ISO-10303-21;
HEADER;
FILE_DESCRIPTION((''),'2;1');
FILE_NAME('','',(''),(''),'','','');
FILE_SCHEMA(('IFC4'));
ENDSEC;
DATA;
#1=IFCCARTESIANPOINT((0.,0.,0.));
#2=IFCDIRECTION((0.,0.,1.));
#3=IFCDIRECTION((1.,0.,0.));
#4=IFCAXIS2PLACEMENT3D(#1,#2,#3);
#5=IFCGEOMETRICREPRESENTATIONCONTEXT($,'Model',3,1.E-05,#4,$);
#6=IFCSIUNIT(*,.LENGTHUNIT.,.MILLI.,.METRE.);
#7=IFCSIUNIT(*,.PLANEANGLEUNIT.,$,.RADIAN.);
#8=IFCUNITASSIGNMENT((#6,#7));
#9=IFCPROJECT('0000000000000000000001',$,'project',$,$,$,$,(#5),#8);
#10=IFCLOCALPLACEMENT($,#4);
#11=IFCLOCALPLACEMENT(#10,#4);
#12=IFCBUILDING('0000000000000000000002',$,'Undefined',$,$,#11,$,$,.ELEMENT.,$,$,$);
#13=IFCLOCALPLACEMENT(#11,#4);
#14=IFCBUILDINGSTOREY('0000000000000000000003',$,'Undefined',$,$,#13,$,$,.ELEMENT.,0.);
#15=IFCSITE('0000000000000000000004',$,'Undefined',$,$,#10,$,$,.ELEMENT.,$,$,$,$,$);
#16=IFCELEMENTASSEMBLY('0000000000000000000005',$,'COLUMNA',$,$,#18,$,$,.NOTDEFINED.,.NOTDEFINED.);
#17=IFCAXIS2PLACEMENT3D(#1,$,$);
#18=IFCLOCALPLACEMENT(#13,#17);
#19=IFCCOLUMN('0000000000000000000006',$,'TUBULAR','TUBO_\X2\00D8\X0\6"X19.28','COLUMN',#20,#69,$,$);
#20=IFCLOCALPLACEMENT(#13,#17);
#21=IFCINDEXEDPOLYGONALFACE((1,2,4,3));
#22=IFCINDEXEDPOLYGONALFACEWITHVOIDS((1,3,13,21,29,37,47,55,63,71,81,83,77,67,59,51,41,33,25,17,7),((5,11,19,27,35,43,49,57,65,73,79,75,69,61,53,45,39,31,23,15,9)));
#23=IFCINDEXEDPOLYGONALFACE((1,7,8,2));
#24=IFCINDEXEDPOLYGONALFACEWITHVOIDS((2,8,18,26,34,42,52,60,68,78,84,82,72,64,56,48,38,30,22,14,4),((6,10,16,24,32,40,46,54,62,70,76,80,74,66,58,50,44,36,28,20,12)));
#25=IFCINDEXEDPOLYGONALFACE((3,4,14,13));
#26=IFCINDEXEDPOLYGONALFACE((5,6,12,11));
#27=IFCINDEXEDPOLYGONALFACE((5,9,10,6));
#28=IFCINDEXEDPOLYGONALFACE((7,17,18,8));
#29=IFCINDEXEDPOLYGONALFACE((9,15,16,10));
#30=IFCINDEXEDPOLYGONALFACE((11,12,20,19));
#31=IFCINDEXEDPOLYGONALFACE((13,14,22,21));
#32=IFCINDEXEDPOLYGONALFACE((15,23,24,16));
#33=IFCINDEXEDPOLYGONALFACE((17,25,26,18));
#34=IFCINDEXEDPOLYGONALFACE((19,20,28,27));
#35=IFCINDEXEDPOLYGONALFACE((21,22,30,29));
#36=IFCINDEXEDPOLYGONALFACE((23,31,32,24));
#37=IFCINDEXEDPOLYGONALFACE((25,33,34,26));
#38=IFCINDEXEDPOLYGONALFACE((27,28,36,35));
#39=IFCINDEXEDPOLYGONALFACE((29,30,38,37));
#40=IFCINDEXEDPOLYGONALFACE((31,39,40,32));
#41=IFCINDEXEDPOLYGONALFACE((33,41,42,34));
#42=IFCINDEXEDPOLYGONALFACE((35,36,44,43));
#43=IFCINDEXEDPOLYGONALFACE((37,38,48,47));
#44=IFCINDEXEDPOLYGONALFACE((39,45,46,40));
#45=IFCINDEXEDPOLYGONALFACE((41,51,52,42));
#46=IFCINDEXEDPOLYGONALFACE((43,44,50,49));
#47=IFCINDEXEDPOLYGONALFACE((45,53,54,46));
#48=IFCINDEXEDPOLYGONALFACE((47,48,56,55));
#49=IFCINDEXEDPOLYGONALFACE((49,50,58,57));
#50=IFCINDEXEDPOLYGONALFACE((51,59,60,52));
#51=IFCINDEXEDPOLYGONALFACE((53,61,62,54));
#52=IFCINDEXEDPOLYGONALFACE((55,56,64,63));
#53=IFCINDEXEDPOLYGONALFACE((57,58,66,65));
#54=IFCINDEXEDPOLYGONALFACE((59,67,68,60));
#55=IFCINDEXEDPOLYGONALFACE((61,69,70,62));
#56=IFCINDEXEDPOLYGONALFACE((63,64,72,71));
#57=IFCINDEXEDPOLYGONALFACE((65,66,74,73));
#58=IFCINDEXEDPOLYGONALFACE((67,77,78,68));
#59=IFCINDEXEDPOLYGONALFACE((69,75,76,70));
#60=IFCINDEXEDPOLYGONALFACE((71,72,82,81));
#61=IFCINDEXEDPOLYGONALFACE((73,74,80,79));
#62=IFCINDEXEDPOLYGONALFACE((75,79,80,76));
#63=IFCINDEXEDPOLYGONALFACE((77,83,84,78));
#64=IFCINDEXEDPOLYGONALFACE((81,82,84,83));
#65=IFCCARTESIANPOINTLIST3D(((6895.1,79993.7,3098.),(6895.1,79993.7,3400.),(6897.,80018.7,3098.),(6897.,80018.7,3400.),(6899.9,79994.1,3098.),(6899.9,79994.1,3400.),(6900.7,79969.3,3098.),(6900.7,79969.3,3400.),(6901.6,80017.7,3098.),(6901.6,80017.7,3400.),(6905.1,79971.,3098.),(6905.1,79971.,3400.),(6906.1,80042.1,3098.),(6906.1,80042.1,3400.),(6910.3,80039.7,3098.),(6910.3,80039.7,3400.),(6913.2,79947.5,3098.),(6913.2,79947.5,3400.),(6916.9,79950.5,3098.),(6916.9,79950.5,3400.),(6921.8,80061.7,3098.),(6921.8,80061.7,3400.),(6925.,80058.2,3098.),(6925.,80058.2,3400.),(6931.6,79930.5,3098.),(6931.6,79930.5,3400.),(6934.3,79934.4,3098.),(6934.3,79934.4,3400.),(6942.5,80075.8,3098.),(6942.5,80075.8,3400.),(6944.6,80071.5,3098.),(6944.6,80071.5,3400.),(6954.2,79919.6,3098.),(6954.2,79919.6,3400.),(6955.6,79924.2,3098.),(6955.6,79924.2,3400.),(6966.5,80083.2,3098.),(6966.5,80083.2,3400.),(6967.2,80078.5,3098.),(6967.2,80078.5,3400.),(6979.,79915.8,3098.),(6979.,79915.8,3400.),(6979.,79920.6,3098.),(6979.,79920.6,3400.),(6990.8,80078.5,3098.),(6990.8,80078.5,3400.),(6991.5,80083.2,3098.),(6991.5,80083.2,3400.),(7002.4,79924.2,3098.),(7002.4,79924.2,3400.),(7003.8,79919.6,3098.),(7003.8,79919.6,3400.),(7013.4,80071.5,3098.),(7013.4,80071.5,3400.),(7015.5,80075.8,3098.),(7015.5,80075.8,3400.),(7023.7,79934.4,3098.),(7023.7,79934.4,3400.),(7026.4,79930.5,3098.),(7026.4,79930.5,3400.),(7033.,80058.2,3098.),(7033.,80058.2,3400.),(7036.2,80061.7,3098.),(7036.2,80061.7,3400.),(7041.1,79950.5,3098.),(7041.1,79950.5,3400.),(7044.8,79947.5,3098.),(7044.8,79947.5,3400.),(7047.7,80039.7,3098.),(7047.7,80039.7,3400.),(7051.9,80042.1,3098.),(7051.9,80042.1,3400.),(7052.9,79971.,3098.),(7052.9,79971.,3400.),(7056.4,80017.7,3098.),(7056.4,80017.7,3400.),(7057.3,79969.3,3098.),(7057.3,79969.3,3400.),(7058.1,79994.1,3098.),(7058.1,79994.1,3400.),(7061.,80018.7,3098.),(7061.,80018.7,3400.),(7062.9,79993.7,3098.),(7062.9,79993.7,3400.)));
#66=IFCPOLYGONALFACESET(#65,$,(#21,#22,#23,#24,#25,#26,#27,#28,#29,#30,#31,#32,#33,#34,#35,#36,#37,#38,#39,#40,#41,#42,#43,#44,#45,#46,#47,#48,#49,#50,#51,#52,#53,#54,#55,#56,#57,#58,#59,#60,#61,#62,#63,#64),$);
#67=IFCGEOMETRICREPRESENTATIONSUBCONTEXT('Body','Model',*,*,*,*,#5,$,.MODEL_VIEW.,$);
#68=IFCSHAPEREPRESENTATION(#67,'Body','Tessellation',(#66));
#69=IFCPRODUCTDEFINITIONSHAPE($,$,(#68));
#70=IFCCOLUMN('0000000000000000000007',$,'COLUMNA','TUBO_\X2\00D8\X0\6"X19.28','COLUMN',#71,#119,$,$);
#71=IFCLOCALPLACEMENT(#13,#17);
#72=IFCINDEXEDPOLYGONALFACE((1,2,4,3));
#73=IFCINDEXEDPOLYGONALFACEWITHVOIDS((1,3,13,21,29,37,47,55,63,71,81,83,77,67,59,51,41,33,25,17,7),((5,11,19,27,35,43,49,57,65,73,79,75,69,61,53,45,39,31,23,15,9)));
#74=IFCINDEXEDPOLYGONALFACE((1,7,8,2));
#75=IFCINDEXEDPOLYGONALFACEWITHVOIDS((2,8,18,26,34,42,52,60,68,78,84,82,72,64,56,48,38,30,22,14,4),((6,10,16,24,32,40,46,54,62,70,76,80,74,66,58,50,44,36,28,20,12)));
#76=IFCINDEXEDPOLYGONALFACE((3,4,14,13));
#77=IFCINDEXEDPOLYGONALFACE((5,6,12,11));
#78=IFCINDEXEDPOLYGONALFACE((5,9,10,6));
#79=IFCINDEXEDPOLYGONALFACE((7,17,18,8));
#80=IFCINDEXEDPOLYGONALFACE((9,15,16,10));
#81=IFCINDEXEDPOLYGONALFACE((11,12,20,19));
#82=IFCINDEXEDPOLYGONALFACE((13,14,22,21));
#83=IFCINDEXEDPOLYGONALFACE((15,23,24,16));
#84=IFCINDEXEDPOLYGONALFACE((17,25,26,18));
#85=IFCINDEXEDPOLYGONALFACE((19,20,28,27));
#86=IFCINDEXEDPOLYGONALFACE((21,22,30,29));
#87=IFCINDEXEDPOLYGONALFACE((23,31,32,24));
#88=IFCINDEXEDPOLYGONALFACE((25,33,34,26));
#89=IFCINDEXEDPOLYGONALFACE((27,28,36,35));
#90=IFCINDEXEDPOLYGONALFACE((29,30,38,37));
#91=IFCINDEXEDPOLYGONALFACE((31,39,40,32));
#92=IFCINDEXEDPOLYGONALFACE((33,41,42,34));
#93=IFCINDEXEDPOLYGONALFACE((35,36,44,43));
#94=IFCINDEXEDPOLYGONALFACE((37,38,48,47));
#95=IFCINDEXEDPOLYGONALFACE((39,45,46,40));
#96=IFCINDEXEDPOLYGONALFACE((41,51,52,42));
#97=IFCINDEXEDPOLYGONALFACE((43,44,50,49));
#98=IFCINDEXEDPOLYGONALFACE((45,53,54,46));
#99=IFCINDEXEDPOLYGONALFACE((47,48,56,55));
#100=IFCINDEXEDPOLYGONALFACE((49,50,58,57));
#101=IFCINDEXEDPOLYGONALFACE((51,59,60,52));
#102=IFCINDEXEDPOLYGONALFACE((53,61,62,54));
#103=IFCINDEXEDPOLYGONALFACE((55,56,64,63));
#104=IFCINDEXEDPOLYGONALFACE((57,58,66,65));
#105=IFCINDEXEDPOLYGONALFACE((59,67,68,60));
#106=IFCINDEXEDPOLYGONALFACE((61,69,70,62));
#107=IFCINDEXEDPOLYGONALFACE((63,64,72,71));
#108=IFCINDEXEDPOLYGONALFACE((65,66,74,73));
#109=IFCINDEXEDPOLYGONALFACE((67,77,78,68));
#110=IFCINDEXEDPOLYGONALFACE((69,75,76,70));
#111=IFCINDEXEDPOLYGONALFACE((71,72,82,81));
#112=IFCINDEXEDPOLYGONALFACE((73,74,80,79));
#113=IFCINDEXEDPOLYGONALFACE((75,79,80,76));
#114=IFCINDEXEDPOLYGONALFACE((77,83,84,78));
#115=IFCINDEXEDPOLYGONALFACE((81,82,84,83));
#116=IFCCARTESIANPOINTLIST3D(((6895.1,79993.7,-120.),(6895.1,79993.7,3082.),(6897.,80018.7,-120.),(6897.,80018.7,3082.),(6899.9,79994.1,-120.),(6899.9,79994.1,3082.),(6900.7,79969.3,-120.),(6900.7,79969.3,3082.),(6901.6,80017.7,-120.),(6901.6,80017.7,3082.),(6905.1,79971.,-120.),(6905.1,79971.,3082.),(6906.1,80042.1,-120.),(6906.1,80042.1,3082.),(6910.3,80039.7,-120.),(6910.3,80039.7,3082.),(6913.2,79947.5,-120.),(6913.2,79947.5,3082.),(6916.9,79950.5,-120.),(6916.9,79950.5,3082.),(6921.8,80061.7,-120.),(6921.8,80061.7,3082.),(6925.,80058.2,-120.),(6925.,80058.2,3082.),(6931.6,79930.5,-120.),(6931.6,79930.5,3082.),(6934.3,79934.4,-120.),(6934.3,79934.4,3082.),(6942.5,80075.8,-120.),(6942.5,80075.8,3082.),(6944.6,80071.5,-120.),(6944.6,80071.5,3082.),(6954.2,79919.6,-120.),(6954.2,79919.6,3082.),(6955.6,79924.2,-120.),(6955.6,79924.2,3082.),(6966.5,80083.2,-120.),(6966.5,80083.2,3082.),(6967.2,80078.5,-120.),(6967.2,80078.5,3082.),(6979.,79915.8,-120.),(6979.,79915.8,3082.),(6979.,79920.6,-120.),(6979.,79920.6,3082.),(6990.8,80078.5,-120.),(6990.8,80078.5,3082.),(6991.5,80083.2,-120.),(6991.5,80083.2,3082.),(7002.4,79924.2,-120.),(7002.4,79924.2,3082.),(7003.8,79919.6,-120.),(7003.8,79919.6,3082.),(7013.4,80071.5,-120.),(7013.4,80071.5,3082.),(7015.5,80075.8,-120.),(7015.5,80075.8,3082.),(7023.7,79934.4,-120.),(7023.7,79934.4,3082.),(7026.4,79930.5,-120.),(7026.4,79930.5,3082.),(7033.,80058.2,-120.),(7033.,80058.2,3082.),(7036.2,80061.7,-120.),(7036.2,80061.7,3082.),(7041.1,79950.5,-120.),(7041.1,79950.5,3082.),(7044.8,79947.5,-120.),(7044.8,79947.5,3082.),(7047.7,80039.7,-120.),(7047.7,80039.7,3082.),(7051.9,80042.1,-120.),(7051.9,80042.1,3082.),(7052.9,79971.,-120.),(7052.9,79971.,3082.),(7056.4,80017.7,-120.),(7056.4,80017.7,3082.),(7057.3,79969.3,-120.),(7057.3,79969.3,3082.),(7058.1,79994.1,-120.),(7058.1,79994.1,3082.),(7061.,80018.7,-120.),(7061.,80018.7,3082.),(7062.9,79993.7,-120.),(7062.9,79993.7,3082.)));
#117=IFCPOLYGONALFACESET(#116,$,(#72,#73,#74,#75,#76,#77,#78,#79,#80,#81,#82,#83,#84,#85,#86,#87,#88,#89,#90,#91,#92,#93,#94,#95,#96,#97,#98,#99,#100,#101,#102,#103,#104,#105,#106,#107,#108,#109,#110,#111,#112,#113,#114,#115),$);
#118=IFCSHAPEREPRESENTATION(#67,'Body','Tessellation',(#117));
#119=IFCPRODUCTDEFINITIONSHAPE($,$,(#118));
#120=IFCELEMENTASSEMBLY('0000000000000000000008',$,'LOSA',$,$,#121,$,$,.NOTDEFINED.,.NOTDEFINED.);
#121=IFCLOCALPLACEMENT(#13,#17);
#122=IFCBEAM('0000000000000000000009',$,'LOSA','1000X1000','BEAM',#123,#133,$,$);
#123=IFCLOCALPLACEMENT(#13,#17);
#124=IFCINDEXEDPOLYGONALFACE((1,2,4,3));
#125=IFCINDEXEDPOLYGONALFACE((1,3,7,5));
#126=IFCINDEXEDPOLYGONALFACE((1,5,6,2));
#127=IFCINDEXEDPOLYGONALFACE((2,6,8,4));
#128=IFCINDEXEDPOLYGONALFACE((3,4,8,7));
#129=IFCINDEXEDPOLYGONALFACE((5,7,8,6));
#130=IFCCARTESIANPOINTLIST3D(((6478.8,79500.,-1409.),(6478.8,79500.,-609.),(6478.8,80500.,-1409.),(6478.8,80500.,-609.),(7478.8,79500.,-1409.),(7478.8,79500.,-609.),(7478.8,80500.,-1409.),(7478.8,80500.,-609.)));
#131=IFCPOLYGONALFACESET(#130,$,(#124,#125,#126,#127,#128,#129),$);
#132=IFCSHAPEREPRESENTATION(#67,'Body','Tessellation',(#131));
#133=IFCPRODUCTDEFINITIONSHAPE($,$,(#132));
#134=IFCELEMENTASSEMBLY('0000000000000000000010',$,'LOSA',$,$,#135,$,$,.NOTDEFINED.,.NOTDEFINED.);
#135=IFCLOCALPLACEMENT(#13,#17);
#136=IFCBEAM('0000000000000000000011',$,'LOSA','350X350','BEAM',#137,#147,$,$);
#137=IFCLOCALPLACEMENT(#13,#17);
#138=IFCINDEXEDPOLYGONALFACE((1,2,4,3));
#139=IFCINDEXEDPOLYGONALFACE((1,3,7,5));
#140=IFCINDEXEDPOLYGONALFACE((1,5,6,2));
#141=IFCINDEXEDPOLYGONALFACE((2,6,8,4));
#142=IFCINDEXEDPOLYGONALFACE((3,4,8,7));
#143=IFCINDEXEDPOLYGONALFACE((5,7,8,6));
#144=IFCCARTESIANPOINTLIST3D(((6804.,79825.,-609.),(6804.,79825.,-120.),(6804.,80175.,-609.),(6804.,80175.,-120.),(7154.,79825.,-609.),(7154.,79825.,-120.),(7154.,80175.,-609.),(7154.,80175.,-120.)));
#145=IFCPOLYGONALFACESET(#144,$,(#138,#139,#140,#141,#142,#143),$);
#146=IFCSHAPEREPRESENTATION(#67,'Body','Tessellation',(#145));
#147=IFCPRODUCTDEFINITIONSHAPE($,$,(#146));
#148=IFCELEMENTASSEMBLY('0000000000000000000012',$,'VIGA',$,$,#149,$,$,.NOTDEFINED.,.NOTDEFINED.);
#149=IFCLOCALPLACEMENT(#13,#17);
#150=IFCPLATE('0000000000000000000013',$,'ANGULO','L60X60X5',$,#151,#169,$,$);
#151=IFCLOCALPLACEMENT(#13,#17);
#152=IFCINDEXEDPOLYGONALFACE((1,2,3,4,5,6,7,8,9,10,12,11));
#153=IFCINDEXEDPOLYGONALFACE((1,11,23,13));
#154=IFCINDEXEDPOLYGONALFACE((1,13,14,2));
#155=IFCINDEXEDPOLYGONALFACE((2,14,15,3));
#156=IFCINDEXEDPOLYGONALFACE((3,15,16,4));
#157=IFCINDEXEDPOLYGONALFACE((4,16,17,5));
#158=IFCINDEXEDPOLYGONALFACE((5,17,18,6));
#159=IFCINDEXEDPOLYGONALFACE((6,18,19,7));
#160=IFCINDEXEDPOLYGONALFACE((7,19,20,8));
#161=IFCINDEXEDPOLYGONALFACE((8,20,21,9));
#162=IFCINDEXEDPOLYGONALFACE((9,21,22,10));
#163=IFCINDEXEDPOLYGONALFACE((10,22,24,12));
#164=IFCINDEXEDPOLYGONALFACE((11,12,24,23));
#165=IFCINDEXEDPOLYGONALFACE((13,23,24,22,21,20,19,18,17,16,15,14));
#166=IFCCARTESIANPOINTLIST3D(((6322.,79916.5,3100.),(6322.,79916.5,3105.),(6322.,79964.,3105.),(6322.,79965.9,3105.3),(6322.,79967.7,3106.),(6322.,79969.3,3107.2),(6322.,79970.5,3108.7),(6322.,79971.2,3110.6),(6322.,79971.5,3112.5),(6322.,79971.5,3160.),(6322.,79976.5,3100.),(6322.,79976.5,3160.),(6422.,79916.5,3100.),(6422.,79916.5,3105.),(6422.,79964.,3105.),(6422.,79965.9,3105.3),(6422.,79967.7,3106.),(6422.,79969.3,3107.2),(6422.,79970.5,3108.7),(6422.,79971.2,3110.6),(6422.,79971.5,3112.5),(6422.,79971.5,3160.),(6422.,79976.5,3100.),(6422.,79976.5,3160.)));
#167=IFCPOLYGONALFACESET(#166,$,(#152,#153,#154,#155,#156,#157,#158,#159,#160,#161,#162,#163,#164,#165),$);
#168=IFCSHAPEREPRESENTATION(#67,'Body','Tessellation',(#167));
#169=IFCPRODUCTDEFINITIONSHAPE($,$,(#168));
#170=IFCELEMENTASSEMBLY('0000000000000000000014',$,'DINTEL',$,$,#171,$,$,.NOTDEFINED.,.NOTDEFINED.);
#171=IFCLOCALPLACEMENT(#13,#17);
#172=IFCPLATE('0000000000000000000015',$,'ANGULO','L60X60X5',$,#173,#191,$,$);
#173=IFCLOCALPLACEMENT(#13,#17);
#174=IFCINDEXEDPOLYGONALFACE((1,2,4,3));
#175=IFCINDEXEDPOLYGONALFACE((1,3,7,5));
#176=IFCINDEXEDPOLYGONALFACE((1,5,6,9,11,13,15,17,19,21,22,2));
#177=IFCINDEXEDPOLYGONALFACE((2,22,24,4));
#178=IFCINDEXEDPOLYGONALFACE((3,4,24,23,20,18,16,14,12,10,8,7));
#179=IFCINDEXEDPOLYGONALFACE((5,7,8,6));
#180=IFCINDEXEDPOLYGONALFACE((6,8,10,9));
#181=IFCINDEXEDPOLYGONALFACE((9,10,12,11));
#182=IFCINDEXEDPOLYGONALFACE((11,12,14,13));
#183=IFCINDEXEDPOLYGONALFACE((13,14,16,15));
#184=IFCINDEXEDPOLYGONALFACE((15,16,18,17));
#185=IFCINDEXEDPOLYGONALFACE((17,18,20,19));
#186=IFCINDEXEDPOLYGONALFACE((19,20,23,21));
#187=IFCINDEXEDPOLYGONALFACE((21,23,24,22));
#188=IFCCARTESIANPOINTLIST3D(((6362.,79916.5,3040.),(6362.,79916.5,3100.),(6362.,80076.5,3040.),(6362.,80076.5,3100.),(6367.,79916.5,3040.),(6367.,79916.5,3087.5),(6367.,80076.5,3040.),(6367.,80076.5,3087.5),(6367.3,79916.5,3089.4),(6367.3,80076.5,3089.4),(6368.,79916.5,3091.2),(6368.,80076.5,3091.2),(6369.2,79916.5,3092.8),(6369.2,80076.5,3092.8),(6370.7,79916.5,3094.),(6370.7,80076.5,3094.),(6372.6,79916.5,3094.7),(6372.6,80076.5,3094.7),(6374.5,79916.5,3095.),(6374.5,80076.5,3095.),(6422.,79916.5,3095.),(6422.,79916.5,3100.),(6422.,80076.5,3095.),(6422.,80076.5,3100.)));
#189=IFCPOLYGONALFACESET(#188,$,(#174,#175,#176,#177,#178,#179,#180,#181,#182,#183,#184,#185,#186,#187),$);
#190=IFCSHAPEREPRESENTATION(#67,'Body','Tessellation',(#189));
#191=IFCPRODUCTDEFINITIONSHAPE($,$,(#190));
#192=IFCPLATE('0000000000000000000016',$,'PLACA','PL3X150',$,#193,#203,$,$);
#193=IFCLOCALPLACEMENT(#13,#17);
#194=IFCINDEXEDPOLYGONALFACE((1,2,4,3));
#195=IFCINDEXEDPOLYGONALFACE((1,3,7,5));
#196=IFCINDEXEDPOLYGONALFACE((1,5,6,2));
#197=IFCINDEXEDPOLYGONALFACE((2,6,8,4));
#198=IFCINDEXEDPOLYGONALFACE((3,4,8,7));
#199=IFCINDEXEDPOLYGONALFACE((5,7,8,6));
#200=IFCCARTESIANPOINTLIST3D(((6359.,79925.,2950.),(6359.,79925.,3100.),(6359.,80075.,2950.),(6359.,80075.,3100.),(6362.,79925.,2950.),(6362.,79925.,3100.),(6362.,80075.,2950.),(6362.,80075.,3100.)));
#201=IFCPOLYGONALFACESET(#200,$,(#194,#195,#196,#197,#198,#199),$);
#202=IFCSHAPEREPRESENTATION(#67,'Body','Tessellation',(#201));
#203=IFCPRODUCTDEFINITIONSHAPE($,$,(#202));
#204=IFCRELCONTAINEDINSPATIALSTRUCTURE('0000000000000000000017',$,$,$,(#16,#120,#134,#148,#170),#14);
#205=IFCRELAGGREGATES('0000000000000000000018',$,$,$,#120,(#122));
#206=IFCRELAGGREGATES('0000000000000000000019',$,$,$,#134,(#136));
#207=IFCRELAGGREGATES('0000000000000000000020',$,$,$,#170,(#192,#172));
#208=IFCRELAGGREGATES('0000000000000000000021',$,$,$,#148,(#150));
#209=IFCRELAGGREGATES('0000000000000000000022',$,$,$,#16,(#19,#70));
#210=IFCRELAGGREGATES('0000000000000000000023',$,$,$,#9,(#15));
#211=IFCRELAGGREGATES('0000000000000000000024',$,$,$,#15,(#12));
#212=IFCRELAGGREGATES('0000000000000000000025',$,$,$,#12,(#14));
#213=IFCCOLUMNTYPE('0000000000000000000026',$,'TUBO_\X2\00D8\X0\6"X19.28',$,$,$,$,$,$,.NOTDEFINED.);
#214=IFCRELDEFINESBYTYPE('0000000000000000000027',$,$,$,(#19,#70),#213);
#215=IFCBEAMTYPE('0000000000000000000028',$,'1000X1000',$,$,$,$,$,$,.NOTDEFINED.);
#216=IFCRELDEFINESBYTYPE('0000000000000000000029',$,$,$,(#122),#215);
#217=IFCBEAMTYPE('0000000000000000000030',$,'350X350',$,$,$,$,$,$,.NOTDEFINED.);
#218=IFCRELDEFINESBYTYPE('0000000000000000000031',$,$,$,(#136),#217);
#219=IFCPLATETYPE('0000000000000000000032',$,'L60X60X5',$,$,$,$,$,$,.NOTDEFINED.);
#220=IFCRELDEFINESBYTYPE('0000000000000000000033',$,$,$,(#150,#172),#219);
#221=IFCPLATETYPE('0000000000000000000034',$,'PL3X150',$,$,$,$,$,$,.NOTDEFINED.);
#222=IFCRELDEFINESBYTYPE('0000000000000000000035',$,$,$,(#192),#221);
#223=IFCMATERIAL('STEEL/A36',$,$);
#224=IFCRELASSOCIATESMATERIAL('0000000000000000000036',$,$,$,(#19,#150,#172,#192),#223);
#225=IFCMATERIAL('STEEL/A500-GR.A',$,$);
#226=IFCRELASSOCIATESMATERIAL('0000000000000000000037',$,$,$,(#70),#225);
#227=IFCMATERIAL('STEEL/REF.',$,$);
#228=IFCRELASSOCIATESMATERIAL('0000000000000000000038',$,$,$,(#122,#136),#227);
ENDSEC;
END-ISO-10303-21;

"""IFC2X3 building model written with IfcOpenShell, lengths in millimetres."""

from ifc_helpers import new_model, si_unit, frame, origin_with_axes, origin_2d_with_axis, place, context, subcontext, project, spatial, polyline, rectangle, hollow_circle, l_section, outline, extrude, material, type_object, element, aggregate, save


model = new_model("IFC2X3")

# Units and contexts
model_context = context("Model", 3, precision=1e-05, world=origin_with_axes())
body_context = subcontext(model_context, "Body", "Model", "MODEL_VIEW")
ifc_project = project(units=[si_unit("LENGTHUNIT", "METRE", prefix="MILLI"), si_unit("PLANEANGLEUNIT", "RADIAN")], contexts=[model_context])

# Site, building, storey
site_placement = place(None, origin_with_axes())
site = spatial("IfcSite", under=ifc_project, at=site_placement, Name="Undefined", CompositionType="ELEMENT")
building_placement = place(site_placement, origin_with_axes())
building = spatial("IfcBuilding", under=site, at=building_placement, Name="Undefined", CompositionType="ELEMENT")
storey_placement = place(building_placement, origin_with_axes())
storey = spatial("IfcBuildingStorey", under=building, at=storey_placement, Name="Undefined", CompositionType="ELEMENT", Elevation=0.0)

# Element assembly, columns
assembly_1_placement = place(storey_placement, origin_with_axes())
assembly_1 = element("IfcElementAssembly", 1, at=assembly_1_placement, inside=storey, Name="COLUMNA", AssemblyPlace="NOTDEFINED", PredefinedType="NOTDEFINED")
ifc_material_1 = material(Name="STEEL/A36")
column_type = type_object("IfcColumnType", Name="TUBO_Ø6\"X19.28", PredefinedType="NOTDEFINED")
column_1_placement = place(assembly_1_placement, frame((6979.0, 80000.0, 3098.0), z_axis=(0.0, 0.0, 1.0), x_axis=(-1.0, 0.0, 0.0)))
column_1 = element("IfcColumn", 2, at=column_1_placement, type_object=column_type, material=ifc_material_1, Name="TUBULAR", Description="TUBO_Ø6\"X19.28", ObjectType="COLUMN", context=body_context, shape_type="SweptSolid", body=[
    extrude(hollow_circle(Radius=84.2, WallThickness=4.8, at=origin_2d_with_axis()), frame((0.0, 0.0, 302.0), z_axis=(0.0, 0.0, -1.0), x_axis=(0.0, 1.0, 0.0)), (0.0, 0.0, 1.0), 302.0),
])
ifc_material_2 = material(Name="STEEL/A500-GR.A")
column_2_placement = place(assembly_1_placement, frame((6979.0, 80000.0, -120.0), z_axis=(0.0, 0.0, 1.0), x_axis=(-1.0, 0.0, 0.0)))
column_2 = element("IfcColumn", 3, at=column_2_placement, type_object=column_type, material=ifc_material_2, Name="COLUMNA", Description="TUBO_Ø6\"X19.28", ObjectType="COLUMN", context=body_context, shape_type="SweptSolid", body=[
    extrude(hollow_circle(Radius=84.2, WallThickness=4.8, at=origin_2d_with_axis()), frame((0.0, 0.0, 3202.0), z_axis=(0.0, 0.0, -1.0), x_axis=(0.0, 1.0, 0.0)), (0.0, 0.0, 1.0), 3202.0),
])

# Element assemblies, beams
assembly_2_placement = place(storey_placement, origin_with_axes())
assembly_2 = element("IfcElementAssembly", 4, at=assembly_2_placement, inside=storey, Name="LOSA", AssemblyPlace="NOTDEFINED", PredefinedType="NOTDEFINED")
ifc_material_3 = material(Name="STEEL/REF.")
beam_type_1 = type_object("IfcBeamType", Name="1000X1000", PredefinedType="NOTDEFINED")
beam_1_placement = place(assembly_2_placement, frame((6978.8, 80000.0, -609.0), z_axis=(1.0, 0.0, 0.0), x_axis=(0.0, 0.0, -1.0)))
beam_1 = element("IfcBeam", 5, at=beam_1_placement, type_object=beam_type_1, material=ifc_material_3, Name="LOSA", Description="1000X1000", ObjectType="BEAM", context=body_context, shape_type="SweptSolid", body=[
    extrude(rectangle(XDim=1000.0, YDim=1000.0, at=origin_2d_with_axis()), frame((800.0, 0.0, 0.0), z_axis=(-1.0, 0.0, 0.0), x_axis=(0.0, -1.0, 0.0)), (0.0, 0.0, 1.0), 800.0),
])
aggregate(assembly_2, [beam_1])
assembly_3_placement = place(storey_placement, origin_with_axes())
assembly_3 = element("IfcElementAssembly", 6, at=assembly_3_placement, inside=storey, Name="LOSA", AssemblyPlace="NOTDEFINED", PredefinedType="NOTDEFINED")
beam_type_2 = type_object("IfcBeamType", Name="350X350", PredefinedType="NOTDEFINED")
beam_2_placement = place(assembly_3_placement, frame((6979.0, 80000.0, -120.0), z_axis=(1.0, 0.0, 0.0), x_axis=(0.0, 0.0, -1.0)))
beam_2 = element("IfcBeam", 7, at=beam_2_placement, type_object=beam_type_2, material=ifc_material_3, Name="LOSA", Description="350X350", ObjectType="BEAM", context=body_context, shape_type="SweptSolid", body=[
    extrude(rectangle(XDim=350.0, YDim=350.0, at=origin_2d_with_axis()), frame((489.0, 0.0, 0.0), z_axis=(-1.0, 0.0, 0.0), x_axis=(0.0, -1.0, 0.0)), (0.0, 0.0, 1.0), 489.0),
])
aggregate(assembly_3, [beam_2])

# Element assembly, plate
assembly_4_placement = place(storey_placement, origin_with_axes())
assembly_4 = element("IfcElementAssembly", 8, at=assembly_4_placement, inside=storey, Name="VIGA", AssemblyPlace="NOTDEFINED", PredefinedType="NOTDEFINED")
plate_type_1 = type_object("IfcPlateType", Name="L60X60X5", PredefinedType="NOTDEFINED")
plate_1_placement = place(assembly_4_placement, frame((6322.0, 79946.5, 3130.0), z_axis=(0.0, 0.0, 1.0), x_axis=(1.0, 0.0, 0.0)))
plate_1 = element("IfcPlate", 9, at=plate_1_placement, type_object=plate_type_1, material=ifc_material_1, Name="ANGULO", Description="L60X60X5", context=body_context, shape_type="SweptSolid", body=[
    extrude(l_section(Depth=60.0, Width=60.0, Thickness=5.0, FilletRadius=7.5, at=origin_2d_with_axis()), frame((100.0, 0.0, 0.0), z_axis=(-1.0, 0.0, 0.0), x_axis=(0.0, -1.0, 0.0)), (0.0, 0.0, 1.0), 100.0),
])

# Element assembly, plates
assembly_5_placement = place(storey_placement, origin_with_axes())
assembly_5 = element("IfcElementAssembly", 10, at=assembly_5_placement, inside=storey, Name="DINTEL", AssemblyPlace="NOTDEFINED", PredefinedType="NOTDEFINED")
plate_2_placement = place(assembly_5_placement, frame((6392.0, 80076.5, 3070.0), z_axis=(0.0, 0.0, -1.0), x_axis=(0.000001, -1.0, 0.0)))
plate_2 = element("IfcPlate", 11, at=plate_2_placement, type_object=plate_type_1, material=ifc_material_1, Name="ANGULO", Description="L60X60X5", context=body_context, shape_type="SweptSolid", body=[
    extrude(l_section(Depth=60.0, Width=60.0, Thickness=5.0, FilletRadius=7.5, at=origin_2d_with_axis()), frame((160.0, 0.0, 0.0), z_axis=(-1.0, 0.0, 0.0), x_axis=(0.0, -1.0, 0.0)), (0.0, 0.0, 1.0), 160.0),
])
plate_type_2 = type_object("IfcPlateType", Name="PL3X150", PredefinedType="NOTDEFINED")
plate_3_placement = place(assembly_5_placement, frame((6360.5, 80075.0, 2950.0), z_axis=(-1.0, 0.0, 0.0), x_axis=(0.0, -1.0, 0.0)))
plate_3 = element("IfcPlate", 12, at=plate_3_placement, type_object=plate_type_2, material=ifc_material_1, Name="PLACA", Description="PL3X150", context=body_context, shape_type="SweptSolid", body=[
    extrude(outline(polyline([(0.0, 0.0), (150.0, 0.0), (150.0, 150.0), (0.0, 150.0), (0.0, 0.0)])), frame((0.0, 0.0, -1.5), z_axis=(0.0, 0.0, 1.0), x_axis=(1.0, 0.0, 0.0)), (0.0, 0.0, 1.0), 3.0),
])
aggregate(assembly_5, [plate_3, plate_2])

aggregate(assembly_4, [plate_1])

aggregate(assembly_1, [column_1, column_2])

save(model, "model.ifc")
